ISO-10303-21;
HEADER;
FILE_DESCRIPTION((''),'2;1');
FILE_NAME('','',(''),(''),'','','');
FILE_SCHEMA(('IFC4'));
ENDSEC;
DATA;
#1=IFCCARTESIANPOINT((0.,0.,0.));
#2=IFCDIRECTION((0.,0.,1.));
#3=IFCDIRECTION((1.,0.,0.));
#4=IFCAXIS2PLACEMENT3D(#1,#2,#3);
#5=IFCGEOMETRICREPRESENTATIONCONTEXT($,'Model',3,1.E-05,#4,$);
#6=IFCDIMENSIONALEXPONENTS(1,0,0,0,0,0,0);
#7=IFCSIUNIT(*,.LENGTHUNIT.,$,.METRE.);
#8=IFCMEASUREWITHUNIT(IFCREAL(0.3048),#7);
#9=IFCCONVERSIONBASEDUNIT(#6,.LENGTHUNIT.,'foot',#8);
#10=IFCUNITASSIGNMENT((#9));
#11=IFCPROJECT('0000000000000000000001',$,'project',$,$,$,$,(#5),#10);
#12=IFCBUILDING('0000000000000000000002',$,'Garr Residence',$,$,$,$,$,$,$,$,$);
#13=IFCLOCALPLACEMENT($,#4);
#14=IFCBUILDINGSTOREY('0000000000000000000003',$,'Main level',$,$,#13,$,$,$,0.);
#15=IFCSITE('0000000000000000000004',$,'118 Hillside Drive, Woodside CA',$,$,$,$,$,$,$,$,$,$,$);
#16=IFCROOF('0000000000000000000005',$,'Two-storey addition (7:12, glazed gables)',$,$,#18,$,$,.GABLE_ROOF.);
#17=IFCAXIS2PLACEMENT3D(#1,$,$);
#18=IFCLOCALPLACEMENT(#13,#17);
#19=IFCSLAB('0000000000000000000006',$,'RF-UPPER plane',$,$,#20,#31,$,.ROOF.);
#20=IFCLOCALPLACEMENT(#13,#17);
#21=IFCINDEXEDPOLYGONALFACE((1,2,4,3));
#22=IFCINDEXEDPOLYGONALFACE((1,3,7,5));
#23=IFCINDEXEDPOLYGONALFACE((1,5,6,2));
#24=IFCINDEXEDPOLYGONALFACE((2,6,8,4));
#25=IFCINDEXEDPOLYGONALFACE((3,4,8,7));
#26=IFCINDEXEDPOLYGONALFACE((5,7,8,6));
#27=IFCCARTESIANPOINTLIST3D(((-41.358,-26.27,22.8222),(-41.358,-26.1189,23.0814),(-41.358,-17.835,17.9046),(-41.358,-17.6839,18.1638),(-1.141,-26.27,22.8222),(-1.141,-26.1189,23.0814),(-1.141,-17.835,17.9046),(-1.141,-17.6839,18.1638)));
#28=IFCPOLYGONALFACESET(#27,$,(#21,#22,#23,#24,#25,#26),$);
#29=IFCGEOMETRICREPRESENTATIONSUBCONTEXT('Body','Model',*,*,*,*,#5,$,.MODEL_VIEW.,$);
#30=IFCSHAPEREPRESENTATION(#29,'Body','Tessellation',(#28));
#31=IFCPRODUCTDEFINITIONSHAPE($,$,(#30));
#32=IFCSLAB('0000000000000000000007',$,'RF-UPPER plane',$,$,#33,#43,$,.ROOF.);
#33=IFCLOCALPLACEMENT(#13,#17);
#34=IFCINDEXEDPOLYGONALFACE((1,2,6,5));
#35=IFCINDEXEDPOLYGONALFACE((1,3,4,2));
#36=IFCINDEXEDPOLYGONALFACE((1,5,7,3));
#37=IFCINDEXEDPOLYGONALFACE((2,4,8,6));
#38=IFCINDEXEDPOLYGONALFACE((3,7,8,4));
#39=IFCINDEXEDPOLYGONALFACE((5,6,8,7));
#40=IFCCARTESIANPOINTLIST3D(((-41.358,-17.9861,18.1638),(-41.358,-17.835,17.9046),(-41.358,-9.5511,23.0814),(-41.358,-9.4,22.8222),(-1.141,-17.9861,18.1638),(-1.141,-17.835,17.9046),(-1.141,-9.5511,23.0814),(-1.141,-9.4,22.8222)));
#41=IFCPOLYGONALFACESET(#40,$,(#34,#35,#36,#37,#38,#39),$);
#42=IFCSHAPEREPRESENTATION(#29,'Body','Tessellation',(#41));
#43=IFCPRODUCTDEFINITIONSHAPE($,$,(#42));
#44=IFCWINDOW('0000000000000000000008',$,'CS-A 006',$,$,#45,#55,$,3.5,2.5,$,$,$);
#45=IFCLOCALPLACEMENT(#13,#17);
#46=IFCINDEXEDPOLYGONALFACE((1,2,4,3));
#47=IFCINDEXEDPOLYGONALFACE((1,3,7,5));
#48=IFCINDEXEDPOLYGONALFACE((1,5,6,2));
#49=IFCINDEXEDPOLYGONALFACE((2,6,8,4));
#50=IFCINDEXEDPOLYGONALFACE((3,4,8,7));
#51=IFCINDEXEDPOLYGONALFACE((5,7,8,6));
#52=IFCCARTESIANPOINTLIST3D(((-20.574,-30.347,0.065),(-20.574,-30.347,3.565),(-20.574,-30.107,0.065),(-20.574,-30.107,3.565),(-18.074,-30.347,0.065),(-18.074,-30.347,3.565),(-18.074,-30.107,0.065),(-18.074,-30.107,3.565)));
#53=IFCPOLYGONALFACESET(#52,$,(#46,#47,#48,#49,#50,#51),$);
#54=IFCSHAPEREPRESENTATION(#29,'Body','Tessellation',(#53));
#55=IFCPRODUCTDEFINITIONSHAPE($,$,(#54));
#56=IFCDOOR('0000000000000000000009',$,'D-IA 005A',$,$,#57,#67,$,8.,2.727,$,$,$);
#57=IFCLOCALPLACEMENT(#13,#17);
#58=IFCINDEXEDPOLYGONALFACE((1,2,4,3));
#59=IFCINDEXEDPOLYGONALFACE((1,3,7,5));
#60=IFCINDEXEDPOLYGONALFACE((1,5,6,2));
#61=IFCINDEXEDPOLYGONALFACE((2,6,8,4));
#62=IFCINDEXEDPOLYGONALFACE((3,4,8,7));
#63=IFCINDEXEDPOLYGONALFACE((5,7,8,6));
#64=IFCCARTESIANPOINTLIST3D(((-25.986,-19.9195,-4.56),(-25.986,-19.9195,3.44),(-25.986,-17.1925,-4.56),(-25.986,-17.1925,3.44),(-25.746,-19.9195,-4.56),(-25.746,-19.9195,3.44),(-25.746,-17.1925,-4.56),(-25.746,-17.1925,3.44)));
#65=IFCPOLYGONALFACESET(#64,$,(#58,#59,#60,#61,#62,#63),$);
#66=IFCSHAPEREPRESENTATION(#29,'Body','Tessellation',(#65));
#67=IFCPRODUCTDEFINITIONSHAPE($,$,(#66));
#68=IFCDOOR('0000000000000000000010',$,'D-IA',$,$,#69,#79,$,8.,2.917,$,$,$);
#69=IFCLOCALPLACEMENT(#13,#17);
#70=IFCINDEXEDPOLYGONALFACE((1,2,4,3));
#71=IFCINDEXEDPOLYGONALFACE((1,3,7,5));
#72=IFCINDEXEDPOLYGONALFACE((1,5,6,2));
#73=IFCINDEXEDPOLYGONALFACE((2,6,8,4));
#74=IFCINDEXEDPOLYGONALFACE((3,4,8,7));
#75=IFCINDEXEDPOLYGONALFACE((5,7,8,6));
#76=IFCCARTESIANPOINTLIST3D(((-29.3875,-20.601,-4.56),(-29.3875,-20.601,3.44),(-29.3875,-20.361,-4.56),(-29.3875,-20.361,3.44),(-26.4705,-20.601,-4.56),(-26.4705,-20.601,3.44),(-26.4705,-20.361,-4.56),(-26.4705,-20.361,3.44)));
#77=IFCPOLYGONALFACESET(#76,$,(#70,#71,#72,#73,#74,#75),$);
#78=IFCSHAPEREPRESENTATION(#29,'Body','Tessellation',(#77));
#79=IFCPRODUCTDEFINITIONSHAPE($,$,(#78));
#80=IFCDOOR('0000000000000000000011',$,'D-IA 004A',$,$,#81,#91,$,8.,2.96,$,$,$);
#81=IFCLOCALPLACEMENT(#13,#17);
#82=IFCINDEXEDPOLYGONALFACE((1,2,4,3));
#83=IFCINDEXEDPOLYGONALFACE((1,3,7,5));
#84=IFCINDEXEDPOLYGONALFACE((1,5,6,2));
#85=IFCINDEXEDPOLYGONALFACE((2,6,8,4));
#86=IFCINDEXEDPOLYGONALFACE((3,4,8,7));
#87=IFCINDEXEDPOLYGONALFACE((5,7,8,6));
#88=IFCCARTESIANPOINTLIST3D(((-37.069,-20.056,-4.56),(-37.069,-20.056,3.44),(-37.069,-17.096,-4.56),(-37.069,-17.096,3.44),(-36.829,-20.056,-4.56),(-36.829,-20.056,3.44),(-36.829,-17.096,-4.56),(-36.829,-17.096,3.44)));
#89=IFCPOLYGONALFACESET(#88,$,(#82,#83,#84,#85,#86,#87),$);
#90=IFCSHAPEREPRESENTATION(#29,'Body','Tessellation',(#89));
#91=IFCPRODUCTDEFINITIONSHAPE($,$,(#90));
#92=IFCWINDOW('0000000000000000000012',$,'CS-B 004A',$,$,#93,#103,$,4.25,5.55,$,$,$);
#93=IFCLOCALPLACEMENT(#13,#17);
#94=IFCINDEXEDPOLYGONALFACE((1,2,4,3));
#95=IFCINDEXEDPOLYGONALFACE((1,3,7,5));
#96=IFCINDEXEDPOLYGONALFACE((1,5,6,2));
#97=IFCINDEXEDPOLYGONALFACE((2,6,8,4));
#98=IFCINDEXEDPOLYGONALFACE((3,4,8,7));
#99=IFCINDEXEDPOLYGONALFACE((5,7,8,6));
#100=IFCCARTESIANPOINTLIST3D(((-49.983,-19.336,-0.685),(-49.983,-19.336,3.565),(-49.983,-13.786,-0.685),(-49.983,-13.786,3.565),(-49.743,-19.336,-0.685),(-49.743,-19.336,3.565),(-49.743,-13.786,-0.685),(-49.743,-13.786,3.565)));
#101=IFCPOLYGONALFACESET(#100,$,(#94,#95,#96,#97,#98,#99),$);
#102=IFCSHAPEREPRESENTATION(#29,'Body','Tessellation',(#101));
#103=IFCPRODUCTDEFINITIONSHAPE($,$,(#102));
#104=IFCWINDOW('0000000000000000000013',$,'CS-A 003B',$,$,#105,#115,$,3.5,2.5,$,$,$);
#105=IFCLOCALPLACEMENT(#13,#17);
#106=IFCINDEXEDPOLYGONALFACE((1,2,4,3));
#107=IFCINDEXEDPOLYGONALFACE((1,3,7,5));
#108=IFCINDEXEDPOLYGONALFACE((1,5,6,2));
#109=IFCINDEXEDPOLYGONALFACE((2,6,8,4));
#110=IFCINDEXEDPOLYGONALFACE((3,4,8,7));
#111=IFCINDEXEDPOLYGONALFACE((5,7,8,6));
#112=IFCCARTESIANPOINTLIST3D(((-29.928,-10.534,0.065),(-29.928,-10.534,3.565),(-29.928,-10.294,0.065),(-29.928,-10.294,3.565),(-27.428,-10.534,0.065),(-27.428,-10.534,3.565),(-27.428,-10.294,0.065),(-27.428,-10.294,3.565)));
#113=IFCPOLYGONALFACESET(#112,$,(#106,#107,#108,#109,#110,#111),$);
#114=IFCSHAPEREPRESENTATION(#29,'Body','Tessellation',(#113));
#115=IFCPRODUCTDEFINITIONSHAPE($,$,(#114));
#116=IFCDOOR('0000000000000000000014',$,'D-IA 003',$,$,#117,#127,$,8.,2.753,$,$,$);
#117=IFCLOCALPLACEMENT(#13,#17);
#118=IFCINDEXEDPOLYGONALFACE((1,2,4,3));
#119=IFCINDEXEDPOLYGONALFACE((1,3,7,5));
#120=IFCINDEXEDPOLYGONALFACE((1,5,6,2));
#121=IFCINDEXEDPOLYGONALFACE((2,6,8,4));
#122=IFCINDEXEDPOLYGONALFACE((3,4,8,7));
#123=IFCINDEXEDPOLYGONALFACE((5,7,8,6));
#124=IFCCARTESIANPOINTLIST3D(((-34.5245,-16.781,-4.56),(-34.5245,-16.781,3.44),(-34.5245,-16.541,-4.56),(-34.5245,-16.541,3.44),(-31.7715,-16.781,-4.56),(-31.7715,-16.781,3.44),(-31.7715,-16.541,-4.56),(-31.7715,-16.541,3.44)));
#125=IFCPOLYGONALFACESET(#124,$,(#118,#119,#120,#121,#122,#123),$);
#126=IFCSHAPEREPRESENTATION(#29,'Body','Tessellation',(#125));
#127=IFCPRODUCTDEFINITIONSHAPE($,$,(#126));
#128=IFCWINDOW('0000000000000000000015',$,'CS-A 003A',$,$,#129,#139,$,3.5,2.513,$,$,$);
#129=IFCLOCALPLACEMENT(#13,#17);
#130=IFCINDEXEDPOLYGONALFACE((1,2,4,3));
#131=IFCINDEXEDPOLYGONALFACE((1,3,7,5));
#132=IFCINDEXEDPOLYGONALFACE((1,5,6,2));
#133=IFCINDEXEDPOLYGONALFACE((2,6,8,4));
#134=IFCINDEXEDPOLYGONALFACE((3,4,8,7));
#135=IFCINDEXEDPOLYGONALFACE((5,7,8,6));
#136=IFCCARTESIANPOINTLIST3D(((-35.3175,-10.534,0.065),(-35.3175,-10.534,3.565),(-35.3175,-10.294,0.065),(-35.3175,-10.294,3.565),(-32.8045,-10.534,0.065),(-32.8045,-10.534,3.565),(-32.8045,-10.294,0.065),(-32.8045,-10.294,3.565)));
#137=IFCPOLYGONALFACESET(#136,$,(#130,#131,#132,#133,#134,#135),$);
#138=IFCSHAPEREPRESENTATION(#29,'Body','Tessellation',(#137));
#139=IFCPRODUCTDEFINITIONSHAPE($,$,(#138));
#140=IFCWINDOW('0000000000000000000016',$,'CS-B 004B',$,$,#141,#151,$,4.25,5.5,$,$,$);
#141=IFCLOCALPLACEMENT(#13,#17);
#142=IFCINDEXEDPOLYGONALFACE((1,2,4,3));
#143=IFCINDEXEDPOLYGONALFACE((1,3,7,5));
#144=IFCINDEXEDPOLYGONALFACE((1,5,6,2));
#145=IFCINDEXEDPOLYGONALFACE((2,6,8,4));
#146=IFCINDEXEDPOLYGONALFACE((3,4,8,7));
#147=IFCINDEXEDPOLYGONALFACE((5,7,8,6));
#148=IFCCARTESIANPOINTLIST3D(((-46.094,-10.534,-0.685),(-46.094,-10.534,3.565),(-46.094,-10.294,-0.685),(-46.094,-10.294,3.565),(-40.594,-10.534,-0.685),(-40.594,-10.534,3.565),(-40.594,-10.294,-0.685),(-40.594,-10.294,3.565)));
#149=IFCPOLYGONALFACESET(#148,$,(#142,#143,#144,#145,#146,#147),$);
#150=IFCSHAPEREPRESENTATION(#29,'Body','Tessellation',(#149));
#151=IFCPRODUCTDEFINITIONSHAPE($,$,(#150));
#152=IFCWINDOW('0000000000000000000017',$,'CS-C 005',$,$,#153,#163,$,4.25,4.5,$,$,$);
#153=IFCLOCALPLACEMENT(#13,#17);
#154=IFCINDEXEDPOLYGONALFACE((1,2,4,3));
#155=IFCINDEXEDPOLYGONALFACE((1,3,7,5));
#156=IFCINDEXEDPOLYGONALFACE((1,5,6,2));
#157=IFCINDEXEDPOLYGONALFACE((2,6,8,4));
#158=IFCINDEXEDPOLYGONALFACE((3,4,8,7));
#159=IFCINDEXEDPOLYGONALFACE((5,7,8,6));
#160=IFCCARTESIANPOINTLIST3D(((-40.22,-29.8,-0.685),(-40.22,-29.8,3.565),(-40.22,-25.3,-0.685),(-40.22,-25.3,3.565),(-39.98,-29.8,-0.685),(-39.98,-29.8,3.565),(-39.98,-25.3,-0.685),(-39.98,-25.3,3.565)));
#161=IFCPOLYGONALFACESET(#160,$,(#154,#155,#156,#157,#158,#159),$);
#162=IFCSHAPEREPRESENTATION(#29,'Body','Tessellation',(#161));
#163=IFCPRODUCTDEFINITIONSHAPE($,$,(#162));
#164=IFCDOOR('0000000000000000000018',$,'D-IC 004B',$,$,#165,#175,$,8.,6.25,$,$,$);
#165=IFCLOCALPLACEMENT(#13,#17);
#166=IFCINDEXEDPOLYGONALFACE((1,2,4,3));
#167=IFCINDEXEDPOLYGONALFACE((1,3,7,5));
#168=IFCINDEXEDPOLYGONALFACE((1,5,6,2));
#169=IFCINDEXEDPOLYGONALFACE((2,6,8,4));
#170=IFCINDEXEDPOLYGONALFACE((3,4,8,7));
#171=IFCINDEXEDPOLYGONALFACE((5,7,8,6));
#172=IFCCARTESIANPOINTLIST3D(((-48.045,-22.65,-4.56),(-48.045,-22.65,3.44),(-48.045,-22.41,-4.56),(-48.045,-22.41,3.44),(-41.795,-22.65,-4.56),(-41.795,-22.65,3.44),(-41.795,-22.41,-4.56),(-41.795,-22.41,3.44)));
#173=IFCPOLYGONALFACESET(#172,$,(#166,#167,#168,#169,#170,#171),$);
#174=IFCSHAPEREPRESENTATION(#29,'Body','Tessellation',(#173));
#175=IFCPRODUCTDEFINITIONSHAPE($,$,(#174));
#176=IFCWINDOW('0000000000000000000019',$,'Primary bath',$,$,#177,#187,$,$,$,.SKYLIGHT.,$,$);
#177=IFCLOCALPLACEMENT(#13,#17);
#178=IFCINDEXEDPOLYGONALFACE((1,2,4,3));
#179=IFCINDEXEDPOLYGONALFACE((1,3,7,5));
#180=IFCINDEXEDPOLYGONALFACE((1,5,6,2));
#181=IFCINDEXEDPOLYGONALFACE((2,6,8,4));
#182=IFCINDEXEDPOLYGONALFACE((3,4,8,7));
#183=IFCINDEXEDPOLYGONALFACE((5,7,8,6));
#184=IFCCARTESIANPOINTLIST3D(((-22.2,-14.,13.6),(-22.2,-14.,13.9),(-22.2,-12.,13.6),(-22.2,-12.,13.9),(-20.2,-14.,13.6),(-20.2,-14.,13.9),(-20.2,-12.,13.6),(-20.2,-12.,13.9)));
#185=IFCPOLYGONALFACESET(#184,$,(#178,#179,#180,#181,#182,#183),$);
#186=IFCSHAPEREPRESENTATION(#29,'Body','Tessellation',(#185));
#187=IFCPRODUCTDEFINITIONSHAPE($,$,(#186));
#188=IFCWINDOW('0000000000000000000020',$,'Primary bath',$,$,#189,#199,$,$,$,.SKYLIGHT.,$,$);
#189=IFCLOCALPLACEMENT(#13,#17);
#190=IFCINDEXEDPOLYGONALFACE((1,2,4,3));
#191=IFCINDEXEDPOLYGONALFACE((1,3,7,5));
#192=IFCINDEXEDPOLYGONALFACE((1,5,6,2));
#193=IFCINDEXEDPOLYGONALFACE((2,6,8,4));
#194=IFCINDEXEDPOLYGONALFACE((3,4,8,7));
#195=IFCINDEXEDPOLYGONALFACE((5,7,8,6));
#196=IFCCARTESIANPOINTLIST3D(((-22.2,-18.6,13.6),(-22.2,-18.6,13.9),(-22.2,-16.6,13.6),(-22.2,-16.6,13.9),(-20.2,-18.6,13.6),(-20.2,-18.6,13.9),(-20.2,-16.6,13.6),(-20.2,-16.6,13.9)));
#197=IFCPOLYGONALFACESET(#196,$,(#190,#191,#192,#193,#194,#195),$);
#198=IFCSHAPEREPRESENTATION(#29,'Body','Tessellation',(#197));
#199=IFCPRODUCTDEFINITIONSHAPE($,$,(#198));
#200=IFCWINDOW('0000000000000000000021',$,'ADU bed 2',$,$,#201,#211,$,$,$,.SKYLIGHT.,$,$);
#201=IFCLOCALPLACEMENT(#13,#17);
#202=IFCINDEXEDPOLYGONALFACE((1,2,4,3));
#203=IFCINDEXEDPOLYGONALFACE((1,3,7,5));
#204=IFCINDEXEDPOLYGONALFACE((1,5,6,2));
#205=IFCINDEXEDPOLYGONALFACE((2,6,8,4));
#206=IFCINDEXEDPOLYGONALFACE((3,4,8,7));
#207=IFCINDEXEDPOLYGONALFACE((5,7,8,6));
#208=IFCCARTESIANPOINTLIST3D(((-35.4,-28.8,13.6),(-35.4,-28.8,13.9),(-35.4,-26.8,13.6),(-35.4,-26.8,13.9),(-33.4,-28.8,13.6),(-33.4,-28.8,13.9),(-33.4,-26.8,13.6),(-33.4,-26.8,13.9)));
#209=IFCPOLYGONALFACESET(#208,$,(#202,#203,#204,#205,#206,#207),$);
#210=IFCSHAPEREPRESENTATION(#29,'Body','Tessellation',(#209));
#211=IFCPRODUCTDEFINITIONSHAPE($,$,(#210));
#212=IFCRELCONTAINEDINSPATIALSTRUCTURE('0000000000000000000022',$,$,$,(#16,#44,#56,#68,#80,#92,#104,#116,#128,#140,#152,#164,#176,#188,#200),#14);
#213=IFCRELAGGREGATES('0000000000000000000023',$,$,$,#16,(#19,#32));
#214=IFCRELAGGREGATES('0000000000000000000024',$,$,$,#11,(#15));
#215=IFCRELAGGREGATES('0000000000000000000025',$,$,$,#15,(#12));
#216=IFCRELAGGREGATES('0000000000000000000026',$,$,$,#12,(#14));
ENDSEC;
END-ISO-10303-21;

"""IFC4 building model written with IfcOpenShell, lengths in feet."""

from ifc_helpers import new_model, entity, si_unit, converted_unit, frame, origin, origin_with_axes, place, context, subcontext, project, spatial, polyline, outline, extrude, element, aggregate, save


model = new_model("IFC4")

# Units and contexts
model_context = context("Model", 3, precision=1e-05, world=origin_with_axes())
body_context = subcontext(model_context, "Body", "Model", "MODEL_VIEW")
ifc_project = project(units=[converted_unit("LENGTHUNIT", "foot", entity("IfcReal", 0.3048), si_unit("LENGTHUNIT", "METRE"), dimensions=[1, 0, 0, 0, 0, 0, 0])], contexts=[model_context])

# Site, building, storey
site = spatial("IfcSite", under=ifc_project, Name="118 Hillside Drive, Woodside CA")
building = spatial("IfcBuilding", under=site, Name="Garr Residence")
storey_placement = place(None, origin_with_axes())
storey = spatial("IfcBuildingStorey", under=building, at=storey_placement, Name="Main level", Elevation=0.0)

# Roof, slabs
roof = element("IfcRoof", 1, inside=storey, Name="Two-storey addition (7:12, glazed gables)", PredefinedType="GABLE_ROOF")
slab_1_placement = place(None, frame((-41.358, -17.835, 17.9046), z_axis=(0.0, 0.503656, 0.863904), x_axis=(1.0, 0.0, 0.0)))
slab_1 = element("IfcSlab", 2, at=slab_1_placement, Name="RF-UPPER plane", PredefinedType="ROOF", context=body_context, shape_type="SweptSolid", body=[
    extrude(outline(polyline([(0.0, 0.0), (40.217, 0.0), (40.217, -9.7638), (0.0, -9.7638), (0.0, 0.0)])), origin(), (0.0, 0.0, 1.0), 0.3),
])
slab_2_placement = place(None, frame((-41.358, -17.835, 17.9046), z_axis=(0.0, -0.503656, 0.863904), x_axis=(1.0, 0.0, 0.0)))
slab_2 = element("IfcSlab", 3, at=slab_2_placement, Name="RF-UPPER plane", PredefinedType="ROOF", context=body_context, shape_type="SweptSolid", body=[
    extrude(outline(polyline([(0.0, 0.0), (40.217, 0.0), (40.217, 9.7638), (0.0, 9.7638), (0.0, 0.0)])), origin(), (0.0, 0.0, 1.0), 0.3),
])
aggregate(roof, [slab_1, slab_2])

# Window
window_1_placement = place(storey_placement, frame((-19.324, -30.227, 0.065), z_axis=(0.0, 0.0, 1.0), x_axis=(1.0, 0.0, 0.0)))
element("IfcWindow", 4, at=window_1_placement, inside=storey, Name="CS-A 006", OverallHeight=3.5, OverallWidth=2.5, context=body_context, shape_type="SweptSolid", body=[
    extrude(outline(polyline([(-1.25, -0.12), (1.25, -0.12), (1.25, 0.12), (-1.25, 0.12), (-1.25, -0.12)])), origin(), (0.0, 0.0, 1.0), 3.5),
])

# Doors
door_1_placement = place(storey_placement, frame((-25.866, -18.556, -4.56), z_axis=(0.0, 0.0, 1.0), x_axis=(0.0, 1.0, 0.0)))
element("IfcDoor", 5, at=door_1_placement, inside=storey, Name="D-IA 005A", OverallHeight=8.0, OverallWidth=2.727, context=body_context, shape_type="SweptSolid", body=[
    extrude(outline(polyline([(-1.3635, -0.12), (1.3635, -0.12), (1.3635, 0.12), (-1.3635, 0.12), (-1.3635, -0.12)])), origin(), (0.0, 0.0, 1.0), 8.0),
])
door_2_placement = place(storey_placement, frame((-27.929, -20.481, -4.56), z_axis=(0.0, 0.0, 1.0), x_axis=(1.0, 0.0, 0.0)))
element("IfcDoor", 6, at=door_2_placement, inside=storey, Name="D-IA", OverallHeight=8.0, OverallWidth=2.917, context=body_context, shape_type="SweptSolid", body=[
    extrude(outline(polyline([(-1.4585, -0.12), (1.4585, -0.12), (1.4585, 0.12), (-1.4585, 0.12), (-1.4585, -0.12)])), origin(), (0.0, 0.0, 1.0), 8.0),
])
door_3_placement = place(storey_placement, frame((-36.949, -18.576, -4.56), z_axis=(0.0, 0.0, 1.0), x_axis=(0.0, 1.0, 0.0)))
element("IfcDoor", 7, at=door_3_placement, inside=storey, Name="D-IA 004A", OverallHeight=8.0, OverallWidth=2.96, context=body_context, shape_type="SweptSolid", body=[
    extrude(outline(polyline([(-1.48, -0.12), (1.48, -0.12), (1.48, 0.12), (-1.48, 0.12), (-1.48, -0.12)])), origin(), (0.0, 0.0, 1.0), 8.0),
])

# Windows
window_2_placement = place(storey_placement, frame((-49.863, -16.561, -0.685), z_axis=(0.0, 0.0, 1.0), x_axis=(0.0, 1.0, 0.0)))
element("IfcWindow", 8, at=window_2_placement, inside=storey, Name="CS-B 004A", OverallHeight=4.25, OverallWidth=5.55, context=body_context, shape_type="SweptSolid", body=[
    extrude(outline(polyline([(-2.775, -0.12), (2.775, -0.12), (2.775, 0.12), (-2.775, 0.12), (-2.775, -0.12)])), origin(), (0.0, 0.0, 1.0), 4.25),
])
window_3_placement = place(storey_placement, frame((-28.678, -10.414, 0.065), z_axis=(0.0, 0.0, 1.0), x_axis=(1.0, 0.0, 0.0)))
element("IfcWindow", 9, at=window_3_placement, inside=storey, Name="CS-A 003B", OverallHeight=3.5, OverallWidth=2.5, context=body_context, shape_type="SweptSolid", body=[
    extrude(outline(polyline([(-1.25, -0.12), (1.25, -0.12), (1.25, 0.12), (-1.25, 0.12), (-1.25, -0.12)])), origin(), (0.0, 0.0, 1.0), 3.5),
])

# Door
door_4_placement = place(storey_placement, frame((-33.148, -16.661, -4.56), z_axis=(0.0, 0.0, 1.0), x_axis=(1.0, 0.0, 0.0)))
element("IfcDoor", 10, at=door_4_placement, inside=storey, Name="D-IA 003", OverallHeight=8.0, OverallWidth=2.753, context=body_context, shape_type="SweptSolid", body=[
    extrude(outline(polyline([(-1.3765, -0.12), (1.3765, -0.12), (1.3765, 0.12), (-1.3765, 0.12), (-1.3765, -0.12)])), origin(), (0.0, 0.0, 1.0), 8.0),
])

# Windows
window_4_placement = place(storey_placement, frame((-34.061, -10.414, 0.065), z_axis=(0.0, 0.0, 1.0), x_axis=(1.0, 0.0, 0.0)))
element("IfcWindow", 11, at=window_4_placement, inside=storey, Name="CS-A 003A", OverallHeight=3.5, OverallWidth=2.513, context=body_context, shape_type="SweptSolid", body=[
    extrude(outline(polyline([(-1.2565, -0.12), (1.2565, -0.12), (1.2565, 0.12), (-1.2565, 0.12), (-1.2565, -0.12)])), origin(), (0.0, 0.0, 1.0), 3.5),
])
window_5_placement = place(storey_placement, frame((-43.344, -10.414, -0.685), z_axis=(0.0, 0.0, 1.0), x_axis=(1.0, 0.0, 0.0)))
element("IfcWindow", 12, at=window_5_placement, inside=storey, Name="CS-B 004B", OverallHeight=4.25, OverallWidth=5.5, context=body_context, shape_type="SweptSolid", body=[
    extrude(outline(polyline([(-2.75, -0.12), (2.75, -0.12), (2.75, 0.12), (-2.75, 0.12), (-2.75, -0.12)])), origin(), (0.0, 0.0, 1.0), 4.25),
])
window_6_placement = place(storey_placement, frame((-40.1, -27.55, -0.685), z_axis=(0.0, 0.0, 1.0), x_axis=(0.0, 1.0, 0.0)))
element("IfcWindow", 13, at=window_6_placement, inside=storey, Name="CS-C 005", OverallHeight=4.25, OverallWidth=4.5, context=body_context, shape_type="SweptSolid", body=[
    extrude(outline(polyline([(-2.25, -0.12), (2.25, -0.12), (2.25, 0.12), (-2.25, 0.12), (-2.25, -0.12)])), origin(), (0.0, 0.0, 1.0), 4.25),
])

# Door
door_5_placement = place(storey_placement, frame((-44.92, -22.53, -4.56), z_axis=(0.0, 0.0, 1.0), x_axis=(1.0, 0.0, 0.0)))
element("IfcDoor", 14, at=door_5_placement, inside=storey, Name="D-IC 004B", OverallHeight=8.0, OverallWidth=6.25, context=body_context, shape_type="SweptSolid", body=[
    extrude(outline(polyline([(-3.125, -0.12), (3.125, -0.12), (3.125, 0.12), (-3.125, 0.12), (-3.125, -0.12)])), origin(), (0.0, 0.0, 1.0), 8.0),
])

# Windows
for number, where, z_axis, x_axis, name in (
    (15, (-21.2, -13.0, 13.6), (0.0, 0.0, 1.0), (1.0, 0.0, 0.0), "Primary bath"),
    (16, (-21.2, -17.6, 13.6), (0.0, 0.0, 1.0), (1.0, 0.0, 0.0), "Primary bath"),
    (17, (-34.4, -27.8, 13.6), (0.0, 0.0, 1.0), (1.0, 0.0, 0.0), "ADU bed 2"),
):
    element("IfcWindow", number, at=place(storey_placement, frame(where, z_axis=z_axis, x_axis=x_axis)), inside=storey, Name=name, PredefinedType="SKYLIGHT", context=body_context, shape_type="SweptSolid", body=[
        extrude(outline(polyline([(-1.0, -1.0), (1.0, -1.0), (1.0, 1.0), (-1.0, 1.0), (-1.0, -1.0)])), origin(), (0.0, 0.0, 1.0), 0.3),
    ])

save(model, "model.ifc")
